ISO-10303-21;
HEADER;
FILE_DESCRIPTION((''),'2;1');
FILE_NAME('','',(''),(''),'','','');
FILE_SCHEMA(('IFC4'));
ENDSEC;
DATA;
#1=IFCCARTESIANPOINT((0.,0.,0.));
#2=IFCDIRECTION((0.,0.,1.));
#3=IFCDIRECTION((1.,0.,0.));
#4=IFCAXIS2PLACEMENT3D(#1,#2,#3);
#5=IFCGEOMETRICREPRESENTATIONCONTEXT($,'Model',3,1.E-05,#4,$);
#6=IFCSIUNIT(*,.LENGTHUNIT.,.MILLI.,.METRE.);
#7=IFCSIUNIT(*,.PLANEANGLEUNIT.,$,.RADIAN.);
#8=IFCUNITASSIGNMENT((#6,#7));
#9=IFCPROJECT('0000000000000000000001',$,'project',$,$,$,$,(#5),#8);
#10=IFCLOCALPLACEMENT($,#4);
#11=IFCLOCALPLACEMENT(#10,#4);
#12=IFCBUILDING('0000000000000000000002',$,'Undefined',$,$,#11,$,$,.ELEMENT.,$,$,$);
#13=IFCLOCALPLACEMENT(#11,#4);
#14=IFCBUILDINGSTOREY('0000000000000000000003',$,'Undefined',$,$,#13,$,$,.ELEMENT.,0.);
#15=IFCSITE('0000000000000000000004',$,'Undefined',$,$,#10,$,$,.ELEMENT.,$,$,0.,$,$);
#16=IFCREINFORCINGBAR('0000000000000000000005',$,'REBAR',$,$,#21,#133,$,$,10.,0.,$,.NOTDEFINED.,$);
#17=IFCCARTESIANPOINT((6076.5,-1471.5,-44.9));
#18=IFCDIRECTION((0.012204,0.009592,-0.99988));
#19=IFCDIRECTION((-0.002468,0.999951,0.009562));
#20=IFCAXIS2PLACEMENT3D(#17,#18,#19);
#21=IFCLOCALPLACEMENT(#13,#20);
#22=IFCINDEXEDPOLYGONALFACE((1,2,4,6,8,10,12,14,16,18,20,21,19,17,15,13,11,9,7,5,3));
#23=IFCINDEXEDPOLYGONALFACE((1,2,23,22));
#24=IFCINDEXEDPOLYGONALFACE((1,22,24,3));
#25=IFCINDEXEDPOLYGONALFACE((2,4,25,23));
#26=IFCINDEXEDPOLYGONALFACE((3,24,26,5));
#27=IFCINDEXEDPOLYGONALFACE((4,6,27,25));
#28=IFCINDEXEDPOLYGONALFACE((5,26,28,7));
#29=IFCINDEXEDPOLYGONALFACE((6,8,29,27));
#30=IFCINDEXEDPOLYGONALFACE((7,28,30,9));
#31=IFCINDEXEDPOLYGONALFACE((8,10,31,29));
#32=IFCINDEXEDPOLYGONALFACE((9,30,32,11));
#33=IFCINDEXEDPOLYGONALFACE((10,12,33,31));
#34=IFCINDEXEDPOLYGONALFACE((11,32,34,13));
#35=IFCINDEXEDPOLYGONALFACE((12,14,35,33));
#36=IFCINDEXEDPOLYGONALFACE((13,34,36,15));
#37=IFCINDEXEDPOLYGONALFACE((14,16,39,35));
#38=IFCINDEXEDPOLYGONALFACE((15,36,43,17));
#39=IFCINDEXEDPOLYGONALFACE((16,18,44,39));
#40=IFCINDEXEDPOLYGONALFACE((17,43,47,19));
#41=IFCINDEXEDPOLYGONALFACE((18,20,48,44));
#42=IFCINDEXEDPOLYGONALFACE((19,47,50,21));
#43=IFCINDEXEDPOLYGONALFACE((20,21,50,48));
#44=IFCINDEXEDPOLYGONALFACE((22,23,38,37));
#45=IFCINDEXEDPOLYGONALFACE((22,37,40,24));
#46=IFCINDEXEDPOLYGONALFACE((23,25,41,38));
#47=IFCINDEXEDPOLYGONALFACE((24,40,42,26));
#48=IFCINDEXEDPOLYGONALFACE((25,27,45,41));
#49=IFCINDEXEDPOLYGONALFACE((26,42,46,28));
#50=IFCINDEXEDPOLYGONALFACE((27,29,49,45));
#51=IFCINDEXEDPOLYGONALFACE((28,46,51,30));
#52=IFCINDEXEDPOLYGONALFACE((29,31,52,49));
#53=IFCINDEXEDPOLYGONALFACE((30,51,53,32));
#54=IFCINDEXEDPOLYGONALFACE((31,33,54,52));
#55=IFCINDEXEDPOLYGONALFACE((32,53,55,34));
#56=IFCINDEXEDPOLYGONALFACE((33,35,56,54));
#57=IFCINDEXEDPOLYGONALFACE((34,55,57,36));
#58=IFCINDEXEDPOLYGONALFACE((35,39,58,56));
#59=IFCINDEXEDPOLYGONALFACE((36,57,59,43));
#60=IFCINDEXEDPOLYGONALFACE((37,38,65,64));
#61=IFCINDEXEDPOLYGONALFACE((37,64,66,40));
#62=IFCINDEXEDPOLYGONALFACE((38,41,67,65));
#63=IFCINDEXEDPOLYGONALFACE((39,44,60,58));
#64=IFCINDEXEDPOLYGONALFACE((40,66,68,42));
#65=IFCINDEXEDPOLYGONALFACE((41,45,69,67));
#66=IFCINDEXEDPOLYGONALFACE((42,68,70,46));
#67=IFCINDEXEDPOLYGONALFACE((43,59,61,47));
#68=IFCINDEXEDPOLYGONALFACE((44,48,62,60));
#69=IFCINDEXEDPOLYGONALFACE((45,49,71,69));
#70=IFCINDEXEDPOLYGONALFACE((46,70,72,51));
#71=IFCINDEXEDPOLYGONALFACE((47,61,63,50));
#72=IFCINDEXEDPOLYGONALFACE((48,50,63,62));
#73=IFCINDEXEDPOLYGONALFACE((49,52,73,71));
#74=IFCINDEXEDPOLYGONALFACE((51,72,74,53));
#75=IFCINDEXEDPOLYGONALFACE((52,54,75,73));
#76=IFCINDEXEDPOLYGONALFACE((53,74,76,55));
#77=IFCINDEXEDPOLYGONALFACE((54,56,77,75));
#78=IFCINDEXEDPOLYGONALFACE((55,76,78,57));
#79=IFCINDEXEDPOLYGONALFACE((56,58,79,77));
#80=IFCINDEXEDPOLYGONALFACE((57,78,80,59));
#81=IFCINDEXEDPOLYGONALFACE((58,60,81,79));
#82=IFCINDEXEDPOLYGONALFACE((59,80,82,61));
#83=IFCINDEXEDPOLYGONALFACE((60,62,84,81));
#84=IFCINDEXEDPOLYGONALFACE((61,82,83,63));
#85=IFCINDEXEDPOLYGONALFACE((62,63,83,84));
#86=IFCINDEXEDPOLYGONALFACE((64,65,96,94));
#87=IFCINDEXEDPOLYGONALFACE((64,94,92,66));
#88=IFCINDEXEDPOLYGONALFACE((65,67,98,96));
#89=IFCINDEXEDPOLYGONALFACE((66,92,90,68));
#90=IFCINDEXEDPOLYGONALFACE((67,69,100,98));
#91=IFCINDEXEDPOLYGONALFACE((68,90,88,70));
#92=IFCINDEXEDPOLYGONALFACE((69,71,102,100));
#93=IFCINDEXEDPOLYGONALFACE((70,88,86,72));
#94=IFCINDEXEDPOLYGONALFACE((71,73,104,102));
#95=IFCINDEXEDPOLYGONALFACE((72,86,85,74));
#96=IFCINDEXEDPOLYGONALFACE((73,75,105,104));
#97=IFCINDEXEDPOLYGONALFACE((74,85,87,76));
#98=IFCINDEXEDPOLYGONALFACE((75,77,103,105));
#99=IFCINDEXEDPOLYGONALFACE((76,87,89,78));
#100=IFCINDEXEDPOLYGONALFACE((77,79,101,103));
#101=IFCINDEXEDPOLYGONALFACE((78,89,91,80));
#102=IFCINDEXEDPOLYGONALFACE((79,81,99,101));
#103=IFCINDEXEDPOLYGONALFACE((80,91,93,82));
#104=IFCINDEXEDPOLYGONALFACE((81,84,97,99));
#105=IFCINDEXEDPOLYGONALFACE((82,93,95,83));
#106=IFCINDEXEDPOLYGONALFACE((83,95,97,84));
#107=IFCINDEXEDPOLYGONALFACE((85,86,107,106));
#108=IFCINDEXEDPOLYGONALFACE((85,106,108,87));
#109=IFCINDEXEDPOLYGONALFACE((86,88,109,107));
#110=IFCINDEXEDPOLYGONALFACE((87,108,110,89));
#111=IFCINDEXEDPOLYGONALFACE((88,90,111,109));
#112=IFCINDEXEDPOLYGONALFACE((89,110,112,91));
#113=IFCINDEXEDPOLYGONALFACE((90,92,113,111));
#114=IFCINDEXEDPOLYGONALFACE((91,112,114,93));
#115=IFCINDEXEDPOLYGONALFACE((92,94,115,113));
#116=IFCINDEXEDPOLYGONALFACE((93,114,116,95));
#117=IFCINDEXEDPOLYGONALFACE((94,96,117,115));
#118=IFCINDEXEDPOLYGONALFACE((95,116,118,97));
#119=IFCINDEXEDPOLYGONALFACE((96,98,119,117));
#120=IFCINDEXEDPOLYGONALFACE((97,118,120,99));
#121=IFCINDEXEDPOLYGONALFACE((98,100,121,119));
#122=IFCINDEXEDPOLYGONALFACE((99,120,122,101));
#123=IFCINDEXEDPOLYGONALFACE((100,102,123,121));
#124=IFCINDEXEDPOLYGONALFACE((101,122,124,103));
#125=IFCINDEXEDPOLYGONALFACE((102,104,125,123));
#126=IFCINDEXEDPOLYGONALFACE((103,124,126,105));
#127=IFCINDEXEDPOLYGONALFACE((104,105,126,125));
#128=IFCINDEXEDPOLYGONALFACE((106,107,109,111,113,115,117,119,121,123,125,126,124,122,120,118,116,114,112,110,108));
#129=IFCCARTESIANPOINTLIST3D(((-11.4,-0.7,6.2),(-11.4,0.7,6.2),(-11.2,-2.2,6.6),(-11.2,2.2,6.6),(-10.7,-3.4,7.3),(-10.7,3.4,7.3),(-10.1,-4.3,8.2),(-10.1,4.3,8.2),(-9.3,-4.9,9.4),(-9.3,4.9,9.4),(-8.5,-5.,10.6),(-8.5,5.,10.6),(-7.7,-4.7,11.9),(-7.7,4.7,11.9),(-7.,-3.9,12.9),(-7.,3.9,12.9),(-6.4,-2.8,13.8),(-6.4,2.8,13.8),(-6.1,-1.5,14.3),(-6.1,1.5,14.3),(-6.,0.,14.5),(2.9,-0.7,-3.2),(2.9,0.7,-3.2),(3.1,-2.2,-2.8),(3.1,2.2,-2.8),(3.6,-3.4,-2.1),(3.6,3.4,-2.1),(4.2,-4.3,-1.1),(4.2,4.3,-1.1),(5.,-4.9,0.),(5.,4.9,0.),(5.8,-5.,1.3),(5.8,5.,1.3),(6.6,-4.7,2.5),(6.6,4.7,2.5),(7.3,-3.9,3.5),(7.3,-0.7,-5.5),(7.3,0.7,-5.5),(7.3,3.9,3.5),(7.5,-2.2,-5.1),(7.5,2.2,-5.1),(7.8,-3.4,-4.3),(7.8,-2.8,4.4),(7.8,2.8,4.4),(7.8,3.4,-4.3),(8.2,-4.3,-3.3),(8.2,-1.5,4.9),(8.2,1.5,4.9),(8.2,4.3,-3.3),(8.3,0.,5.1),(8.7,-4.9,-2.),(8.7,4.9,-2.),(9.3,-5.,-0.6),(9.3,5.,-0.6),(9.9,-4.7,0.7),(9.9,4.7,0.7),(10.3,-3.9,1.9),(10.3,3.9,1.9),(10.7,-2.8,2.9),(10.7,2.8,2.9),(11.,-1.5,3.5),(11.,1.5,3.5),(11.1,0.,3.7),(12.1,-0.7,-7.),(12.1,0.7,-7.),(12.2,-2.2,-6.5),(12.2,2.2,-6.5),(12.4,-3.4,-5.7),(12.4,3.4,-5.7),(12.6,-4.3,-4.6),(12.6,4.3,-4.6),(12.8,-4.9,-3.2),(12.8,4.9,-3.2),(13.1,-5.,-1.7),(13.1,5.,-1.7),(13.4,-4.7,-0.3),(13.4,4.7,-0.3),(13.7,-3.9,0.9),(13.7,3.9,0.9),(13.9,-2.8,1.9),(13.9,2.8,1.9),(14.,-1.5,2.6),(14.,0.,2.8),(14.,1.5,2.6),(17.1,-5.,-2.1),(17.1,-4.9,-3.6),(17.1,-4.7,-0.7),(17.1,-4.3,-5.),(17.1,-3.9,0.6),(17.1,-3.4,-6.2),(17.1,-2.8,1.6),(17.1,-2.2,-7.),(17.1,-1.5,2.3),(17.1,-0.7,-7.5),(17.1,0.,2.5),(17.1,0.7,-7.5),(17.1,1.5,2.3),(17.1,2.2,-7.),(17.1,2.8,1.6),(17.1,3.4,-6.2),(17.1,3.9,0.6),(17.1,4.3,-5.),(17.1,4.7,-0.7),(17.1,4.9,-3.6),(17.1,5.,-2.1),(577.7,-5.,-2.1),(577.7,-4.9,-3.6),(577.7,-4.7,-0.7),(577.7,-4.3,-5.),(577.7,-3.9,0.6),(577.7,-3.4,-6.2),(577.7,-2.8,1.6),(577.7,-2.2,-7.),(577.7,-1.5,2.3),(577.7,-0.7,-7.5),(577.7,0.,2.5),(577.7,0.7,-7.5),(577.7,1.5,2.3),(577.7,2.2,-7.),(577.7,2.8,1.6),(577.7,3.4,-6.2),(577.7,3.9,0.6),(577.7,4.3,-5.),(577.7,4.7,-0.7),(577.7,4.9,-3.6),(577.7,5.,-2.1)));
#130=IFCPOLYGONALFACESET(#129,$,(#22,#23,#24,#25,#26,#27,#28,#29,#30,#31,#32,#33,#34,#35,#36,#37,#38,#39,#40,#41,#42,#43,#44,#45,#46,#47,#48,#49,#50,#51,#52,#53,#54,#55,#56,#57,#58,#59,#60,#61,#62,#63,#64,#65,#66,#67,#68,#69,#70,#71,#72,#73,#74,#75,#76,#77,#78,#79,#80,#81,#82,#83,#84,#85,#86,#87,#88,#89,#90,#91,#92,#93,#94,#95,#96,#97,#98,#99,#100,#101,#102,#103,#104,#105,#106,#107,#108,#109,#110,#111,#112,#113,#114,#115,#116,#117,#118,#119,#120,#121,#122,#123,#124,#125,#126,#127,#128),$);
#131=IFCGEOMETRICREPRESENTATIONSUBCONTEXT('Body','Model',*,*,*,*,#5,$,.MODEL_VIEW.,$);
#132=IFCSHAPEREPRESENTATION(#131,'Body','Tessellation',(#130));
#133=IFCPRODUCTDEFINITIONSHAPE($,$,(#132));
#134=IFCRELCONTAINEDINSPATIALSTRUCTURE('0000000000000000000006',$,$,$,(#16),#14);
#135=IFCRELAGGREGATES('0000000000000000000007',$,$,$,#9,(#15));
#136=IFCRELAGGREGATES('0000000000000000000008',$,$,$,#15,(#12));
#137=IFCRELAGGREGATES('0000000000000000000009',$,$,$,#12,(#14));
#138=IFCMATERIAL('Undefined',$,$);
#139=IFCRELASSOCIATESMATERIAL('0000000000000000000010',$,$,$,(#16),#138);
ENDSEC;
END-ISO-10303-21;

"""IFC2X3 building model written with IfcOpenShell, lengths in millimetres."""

from ifc_helpers import new_model, entity, si_unit, frame, origin_with_axes, place, context, subcontext, project, spatial, source, transform, mapped, material, element, save


model = new_model("IFC2X3")

# Units and contexts
model_context = context("Model", 3, precision=1e-05, world=origin_with_axes())
body_context = subcontext(model_context, "Body", "Model", "MODEL_VIEW")
ifc_project = project(units=[si_unit("LENGTHUNIT", "METRE", prefix="MILLI"), si_unit("PLANEANGLEUNIT", "RADIAN")], contexts=[model_context])

# Site, building, storey
site_placement = place(None, origin_with_axes())
site = spatial("IfcSite", under=ifc_project, at=site_placement, Name="Undefined", CompositionType="ELEMENT", RefElevation=0.0)
building_placement = place(site_placement, origin_with_axes())
building = spatial("IfcBuilding", under=site, at=building_placement, Name="Undefined", CompositionType="ELEMENT")
storey_placement = place(building_placement, origin_with_axes())
storey = spatial("IfcBuildingStorey", under=building, at=storey_placement, Name="Undefined", CompositionType="ELEMENT", Elevation=0.0)

# Reinforcing bar
ifc_material_1 = material(Name="Undefined")
shared_shape_1 = source(origin_with_axes(), body_context, "Body", "AdvancedSweptSolid", [
    entity("IfcSweptDiskSolid", entity("IfcCompositeCurve", [entity("IfcCompositeCurveSegment", "CONTINUOUS", True, entity("IfcTrimmedCurve", entity("IfcLine", entity("IfcCartesianPoint", [0.0, 0.0, 0.0]), entity("IfcVector", entity("IfcDirection", [0.835483, 0.0, -0.549516]), 1.0)), [entity("IfcParameterValue", 0.0)], [entity("IfcParameterValue", 17.082101)], True, "PARAMETER")), entity("IfcCompositeCurveSegment", "CONTINUOUS", True, entity("IfcTrimmedCurve", entity("IfcCircle", entity("IfcAxis2Placement3D", entity("IfcCartesianPoint", [25.8, 0.0, 8.2]), entity("IfcDirection", [0.0, -1.0, 0.0]), entity("IfcDirection", [-0.549516, 0.0, -0.835483])), 21.0), [entity("IfcParameterValue", 0.0)], [entity("IfcParameterValue", 0.581785)], True, "PARAMETER")), entity("IfcCompositeCurveSegment", "DISCONTINUOUS", True, entity("IfcTrimmedCurve", entity("IfcLine", entity("IfcCartesianPoint", [25.8, 0.0, -12.8]), entity("IfcVector", entity("IfcDirection", [1.0, 0.0, 0.0]), 1.0)), [entity("IfcParameterValue", 0.0)], [entity("IfcParameterValue", 560.593055)], True, "PARAMETER"))], False), 5.0, None, 0.0, 578.3),
])
reinforcing_bar_1_placement = place(storey_placement, frame((6076.5, -1471.5, -44.9), z_axis=(0.012204, 0.009592, -0.99988), x_axis=(-0.002468, 0.999951, 0.009562)))
element("IfcReinforcingBar", 1, at=reinforcing_bar_1_placement, inside=storey, material=ifc_material_1, Name="REBAR", BarRole="NOTDEFINED", CrossSectionArea=0.0, NominalDiameter=10.0, context=body_context, shape_type="MappedRepresentation", body=[
    mapped(shared_shape_1, transform((-8.7, 0.0, 10.3))),
])

save(model, "model.ifc")
